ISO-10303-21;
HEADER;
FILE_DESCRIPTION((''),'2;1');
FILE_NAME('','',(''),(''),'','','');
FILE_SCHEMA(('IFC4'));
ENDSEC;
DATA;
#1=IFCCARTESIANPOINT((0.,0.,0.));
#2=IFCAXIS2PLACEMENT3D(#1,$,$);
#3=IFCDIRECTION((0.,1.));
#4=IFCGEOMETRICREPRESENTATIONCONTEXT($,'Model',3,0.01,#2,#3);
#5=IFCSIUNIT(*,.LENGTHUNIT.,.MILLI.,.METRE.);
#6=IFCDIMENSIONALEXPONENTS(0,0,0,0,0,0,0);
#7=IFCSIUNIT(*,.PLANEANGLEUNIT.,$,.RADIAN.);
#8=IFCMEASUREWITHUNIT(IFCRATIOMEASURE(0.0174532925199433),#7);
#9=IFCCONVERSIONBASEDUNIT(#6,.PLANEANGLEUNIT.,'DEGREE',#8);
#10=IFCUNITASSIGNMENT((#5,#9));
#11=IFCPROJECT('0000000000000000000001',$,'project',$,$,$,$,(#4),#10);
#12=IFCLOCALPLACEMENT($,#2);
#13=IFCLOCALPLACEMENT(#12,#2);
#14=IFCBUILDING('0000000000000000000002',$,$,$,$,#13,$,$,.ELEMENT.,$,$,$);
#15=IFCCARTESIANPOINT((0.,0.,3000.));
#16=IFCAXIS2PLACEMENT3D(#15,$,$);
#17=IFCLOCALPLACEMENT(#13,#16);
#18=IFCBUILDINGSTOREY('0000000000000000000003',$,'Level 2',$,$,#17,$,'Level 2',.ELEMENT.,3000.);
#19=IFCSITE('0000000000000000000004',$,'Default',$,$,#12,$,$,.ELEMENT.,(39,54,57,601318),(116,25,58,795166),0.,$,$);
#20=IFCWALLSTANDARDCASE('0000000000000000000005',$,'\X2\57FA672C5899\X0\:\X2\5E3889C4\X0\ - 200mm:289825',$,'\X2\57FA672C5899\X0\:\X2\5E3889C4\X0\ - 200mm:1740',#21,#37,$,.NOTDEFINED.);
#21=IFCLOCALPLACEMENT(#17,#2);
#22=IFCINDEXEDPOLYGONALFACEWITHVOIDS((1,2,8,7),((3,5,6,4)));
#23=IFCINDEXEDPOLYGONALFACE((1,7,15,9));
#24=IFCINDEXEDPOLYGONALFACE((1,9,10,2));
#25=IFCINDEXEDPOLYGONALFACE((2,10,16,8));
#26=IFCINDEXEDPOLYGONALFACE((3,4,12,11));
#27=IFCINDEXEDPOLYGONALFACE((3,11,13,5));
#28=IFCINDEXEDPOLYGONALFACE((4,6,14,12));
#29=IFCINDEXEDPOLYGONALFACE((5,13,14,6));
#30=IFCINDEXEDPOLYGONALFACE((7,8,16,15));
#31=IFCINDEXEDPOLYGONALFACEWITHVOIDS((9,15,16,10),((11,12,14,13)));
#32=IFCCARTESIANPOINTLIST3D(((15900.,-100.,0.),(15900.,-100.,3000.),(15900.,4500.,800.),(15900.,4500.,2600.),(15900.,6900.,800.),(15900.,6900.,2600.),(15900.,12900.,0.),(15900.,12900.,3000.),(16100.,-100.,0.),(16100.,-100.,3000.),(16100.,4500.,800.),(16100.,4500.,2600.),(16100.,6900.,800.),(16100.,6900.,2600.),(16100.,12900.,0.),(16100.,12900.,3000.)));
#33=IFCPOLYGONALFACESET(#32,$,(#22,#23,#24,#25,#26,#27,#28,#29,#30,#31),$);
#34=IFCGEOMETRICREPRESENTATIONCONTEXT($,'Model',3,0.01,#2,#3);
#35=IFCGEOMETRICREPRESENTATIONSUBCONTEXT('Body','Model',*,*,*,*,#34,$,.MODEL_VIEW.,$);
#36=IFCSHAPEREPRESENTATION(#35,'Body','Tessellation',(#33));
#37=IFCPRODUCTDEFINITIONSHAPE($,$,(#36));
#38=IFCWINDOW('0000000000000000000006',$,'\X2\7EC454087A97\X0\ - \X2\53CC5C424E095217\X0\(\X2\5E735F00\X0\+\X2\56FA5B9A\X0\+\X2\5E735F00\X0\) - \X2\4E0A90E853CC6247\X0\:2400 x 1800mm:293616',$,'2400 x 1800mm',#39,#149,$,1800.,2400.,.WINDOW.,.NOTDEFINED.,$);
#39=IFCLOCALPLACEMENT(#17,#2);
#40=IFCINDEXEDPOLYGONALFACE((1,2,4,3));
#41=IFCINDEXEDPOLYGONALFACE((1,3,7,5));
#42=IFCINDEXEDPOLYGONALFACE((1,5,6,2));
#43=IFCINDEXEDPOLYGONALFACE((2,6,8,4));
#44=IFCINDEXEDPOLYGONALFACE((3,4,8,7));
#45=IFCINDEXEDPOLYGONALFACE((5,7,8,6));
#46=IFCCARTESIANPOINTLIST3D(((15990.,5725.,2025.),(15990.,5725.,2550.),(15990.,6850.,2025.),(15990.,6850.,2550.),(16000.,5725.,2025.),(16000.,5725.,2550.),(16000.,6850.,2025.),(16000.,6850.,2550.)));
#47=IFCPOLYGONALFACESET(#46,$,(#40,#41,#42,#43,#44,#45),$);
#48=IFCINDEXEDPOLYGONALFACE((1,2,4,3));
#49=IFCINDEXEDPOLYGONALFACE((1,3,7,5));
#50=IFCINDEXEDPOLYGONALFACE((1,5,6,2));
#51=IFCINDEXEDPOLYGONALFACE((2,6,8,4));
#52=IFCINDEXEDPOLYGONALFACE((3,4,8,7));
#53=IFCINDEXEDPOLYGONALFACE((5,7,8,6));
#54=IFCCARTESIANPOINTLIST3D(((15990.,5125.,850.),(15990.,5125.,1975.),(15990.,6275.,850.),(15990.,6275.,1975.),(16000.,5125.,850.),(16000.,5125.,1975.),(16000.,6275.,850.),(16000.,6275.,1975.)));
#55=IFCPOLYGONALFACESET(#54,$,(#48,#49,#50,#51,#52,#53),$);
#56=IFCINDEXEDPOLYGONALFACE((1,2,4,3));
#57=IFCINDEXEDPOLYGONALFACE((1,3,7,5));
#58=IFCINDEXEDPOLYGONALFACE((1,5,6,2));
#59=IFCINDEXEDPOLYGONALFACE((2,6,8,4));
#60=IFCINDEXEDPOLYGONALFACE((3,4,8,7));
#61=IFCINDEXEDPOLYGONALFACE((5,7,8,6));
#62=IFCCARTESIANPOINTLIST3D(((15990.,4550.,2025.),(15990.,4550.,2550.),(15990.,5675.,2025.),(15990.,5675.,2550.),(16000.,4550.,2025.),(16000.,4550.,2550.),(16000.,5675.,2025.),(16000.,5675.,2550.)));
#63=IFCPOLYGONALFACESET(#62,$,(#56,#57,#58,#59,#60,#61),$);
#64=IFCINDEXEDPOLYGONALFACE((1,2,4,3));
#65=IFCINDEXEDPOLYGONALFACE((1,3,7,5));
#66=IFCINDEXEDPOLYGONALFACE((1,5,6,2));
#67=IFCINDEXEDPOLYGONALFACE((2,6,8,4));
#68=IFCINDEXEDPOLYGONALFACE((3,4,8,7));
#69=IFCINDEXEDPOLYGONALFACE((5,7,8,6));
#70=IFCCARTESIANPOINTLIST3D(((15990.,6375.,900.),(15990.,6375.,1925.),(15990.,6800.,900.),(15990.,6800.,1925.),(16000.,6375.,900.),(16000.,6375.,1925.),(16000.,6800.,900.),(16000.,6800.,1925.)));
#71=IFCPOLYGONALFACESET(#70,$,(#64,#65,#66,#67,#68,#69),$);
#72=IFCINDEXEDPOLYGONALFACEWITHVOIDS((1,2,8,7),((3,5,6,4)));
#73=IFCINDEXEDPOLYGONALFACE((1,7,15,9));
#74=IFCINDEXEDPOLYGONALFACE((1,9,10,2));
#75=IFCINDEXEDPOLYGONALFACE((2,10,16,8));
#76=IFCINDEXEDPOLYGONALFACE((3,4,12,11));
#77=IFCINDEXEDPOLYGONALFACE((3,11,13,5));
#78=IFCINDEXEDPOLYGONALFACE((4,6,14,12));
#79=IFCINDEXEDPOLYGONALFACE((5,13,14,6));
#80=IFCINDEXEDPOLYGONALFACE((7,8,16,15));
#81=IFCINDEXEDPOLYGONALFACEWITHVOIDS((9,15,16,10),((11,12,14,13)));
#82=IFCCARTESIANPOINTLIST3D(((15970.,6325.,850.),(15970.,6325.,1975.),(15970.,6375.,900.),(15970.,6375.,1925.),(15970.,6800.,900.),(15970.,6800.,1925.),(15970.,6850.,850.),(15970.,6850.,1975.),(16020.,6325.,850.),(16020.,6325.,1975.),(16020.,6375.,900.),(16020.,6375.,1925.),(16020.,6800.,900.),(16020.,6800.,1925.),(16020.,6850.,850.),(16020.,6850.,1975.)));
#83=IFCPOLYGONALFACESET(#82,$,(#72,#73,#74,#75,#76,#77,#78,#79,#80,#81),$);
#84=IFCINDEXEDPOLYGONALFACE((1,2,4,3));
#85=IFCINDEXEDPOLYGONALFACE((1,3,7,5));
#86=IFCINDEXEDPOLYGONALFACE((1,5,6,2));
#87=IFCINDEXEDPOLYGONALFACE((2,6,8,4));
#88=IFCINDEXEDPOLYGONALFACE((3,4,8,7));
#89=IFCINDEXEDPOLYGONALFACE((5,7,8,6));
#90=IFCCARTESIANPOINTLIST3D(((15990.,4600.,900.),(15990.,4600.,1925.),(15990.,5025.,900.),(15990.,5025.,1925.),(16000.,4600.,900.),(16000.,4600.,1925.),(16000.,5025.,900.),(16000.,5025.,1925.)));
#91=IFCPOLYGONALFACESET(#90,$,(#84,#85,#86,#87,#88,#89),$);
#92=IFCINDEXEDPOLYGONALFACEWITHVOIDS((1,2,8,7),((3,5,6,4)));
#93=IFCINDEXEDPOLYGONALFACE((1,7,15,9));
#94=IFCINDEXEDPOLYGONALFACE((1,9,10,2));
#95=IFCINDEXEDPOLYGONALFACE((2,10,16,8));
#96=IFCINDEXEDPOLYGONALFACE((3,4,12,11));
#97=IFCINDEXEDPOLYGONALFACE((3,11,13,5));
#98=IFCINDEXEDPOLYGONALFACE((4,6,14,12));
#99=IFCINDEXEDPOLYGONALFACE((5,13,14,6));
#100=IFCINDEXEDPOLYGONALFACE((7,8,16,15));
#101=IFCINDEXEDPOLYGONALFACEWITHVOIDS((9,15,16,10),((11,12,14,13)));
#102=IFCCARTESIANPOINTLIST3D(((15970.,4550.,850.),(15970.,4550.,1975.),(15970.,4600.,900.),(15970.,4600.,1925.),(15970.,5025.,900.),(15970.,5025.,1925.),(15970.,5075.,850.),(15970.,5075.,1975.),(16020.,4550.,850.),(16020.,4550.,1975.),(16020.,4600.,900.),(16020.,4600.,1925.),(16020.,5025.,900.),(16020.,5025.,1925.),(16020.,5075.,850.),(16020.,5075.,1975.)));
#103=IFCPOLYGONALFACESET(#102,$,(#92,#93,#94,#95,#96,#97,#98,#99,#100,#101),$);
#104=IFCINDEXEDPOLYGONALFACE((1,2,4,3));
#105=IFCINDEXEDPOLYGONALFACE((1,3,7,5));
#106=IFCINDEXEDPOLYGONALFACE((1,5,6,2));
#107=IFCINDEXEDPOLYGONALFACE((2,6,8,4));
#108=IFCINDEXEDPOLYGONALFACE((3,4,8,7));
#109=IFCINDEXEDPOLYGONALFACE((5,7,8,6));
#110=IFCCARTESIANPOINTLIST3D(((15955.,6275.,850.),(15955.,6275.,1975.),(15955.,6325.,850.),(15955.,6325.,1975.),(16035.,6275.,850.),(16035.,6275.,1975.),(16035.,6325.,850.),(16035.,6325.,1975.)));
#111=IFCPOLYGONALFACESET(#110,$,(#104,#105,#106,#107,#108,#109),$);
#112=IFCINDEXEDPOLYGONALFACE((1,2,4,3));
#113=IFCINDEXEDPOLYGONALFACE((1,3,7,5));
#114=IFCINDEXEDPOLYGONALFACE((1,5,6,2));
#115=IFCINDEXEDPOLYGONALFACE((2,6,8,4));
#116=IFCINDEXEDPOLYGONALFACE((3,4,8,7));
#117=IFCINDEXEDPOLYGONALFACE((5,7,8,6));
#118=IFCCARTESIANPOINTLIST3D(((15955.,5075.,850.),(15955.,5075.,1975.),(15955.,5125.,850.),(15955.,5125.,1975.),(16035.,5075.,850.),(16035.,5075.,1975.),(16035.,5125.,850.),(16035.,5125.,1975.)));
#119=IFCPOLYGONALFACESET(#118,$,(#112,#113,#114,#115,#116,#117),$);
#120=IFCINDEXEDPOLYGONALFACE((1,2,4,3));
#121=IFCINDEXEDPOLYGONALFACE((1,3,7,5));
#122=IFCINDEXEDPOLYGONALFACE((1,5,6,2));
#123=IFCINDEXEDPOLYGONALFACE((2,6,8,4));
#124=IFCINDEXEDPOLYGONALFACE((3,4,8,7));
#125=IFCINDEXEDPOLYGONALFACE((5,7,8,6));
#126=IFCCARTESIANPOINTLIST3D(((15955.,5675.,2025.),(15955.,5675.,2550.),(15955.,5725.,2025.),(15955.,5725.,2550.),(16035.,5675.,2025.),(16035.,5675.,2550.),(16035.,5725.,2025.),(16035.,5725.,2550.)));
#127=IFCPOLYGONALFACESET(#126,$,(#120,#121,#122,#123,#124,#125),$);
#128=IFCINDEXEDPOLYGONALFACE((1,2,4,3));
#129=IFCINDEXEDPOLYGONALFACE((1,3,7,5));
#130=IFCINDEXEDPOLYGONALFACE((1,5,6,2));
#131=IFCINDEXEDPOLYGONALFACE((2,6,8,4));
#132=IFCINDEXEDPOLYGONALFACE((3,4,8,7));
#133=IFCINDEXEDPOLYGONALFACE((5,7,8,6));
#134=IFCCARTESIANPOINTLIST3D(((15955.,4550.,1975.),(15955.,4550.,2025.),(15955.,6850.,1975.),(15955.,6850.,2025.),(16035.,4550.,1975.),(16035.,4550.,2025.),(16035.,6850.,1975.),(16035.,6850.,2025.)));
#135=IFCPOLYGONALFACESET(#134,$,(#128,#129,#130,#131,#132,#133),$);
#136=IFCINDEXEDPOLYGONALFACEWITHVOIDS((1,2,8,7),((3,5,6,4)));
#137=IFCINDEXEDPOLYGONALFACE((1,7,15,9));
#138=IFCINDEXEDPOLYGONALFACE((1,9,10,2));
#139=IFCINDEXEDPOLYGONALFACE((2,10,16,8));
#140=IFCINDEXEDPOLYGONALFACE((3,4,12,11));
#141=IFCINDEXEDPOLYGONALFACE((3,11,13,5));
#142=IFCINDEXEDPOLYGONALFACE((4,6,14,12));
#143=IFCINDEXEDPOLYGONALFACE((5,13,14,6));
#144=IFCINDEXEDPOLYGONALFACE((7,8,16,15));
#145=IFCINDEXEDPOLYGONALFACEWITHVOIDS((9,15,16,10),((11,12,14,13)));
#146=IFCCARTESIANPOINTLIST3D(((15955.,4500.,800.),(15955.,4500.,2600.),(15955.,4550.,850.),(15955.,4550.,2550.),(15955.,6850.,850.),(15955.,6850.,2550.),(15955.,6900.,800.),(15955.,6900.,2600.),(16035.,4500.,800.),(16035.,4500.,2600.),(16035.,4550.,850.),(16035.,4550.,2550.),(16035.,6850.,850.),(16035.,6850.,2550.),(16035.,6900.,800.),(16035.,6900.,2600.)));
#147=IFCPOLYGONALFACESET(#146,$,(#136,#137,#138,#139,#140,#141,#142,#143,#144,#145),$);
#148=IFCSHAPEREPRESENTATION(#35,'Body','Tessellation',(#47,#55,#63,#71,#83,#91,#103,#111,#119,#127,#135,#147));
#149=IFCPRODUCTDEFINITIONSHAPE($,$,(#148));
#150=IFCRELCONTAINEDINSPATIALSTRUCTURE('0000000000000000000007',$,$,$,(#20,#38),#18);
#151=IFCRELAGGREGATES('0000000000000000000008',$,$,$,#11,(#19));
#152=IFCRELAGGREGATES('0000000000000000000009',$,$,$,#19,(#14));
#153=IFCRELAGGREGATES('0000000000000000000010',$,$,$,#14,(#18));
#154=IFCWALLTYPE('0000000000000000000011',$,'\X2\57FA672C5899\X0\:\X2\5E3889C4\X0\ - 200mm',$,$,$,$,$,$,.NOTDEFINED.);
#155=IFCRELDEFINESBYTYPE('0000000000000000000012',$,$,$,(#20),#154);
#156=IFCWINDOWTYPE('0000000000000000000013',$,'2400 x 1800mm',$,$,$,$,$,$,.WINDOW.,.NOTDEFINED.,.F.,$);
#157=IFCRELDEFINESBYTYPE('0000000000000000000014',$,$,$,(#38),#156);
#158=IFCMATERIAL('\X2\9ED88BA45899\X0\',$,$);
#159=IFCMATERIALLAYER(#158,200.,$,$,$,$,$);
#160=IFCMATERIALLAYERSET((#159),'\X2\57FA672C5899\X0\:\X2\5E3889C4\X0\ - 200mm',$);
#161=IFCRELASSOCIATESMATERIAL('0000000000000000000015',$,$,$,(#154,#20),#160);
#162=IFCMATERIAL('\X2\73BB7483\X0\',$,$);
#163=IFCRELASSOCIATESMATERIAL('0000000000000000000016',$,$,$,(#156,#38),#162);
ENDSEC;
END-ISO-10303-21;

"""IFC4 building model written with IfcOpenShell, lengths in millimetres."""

from ifc_helpers import new_model, entity, si_unit, converted_unit, direction, frame, frame_2d, origin, origin_2d_with_axis, place, context, subcontext, project, spatial, polyline, rectangle, outline, extrude, source, transform, mapped, material, layer, layer_set, layer_usage, type_object, type_shapes, element, fill, save


model = new_model("IFC4")

# Units and contexts
model_context_1 = context("Model", 3, precision=0.01, world=origin(), true_north=direction((0.0, 1.0)))
model_context_2 = context("Model", 3, precision=0.01, world=origin(), true_north=direction((0.0, 1.0)))
body_context = subcontext(model_context_2, "Body", "Model", "MODEL_VIEW")
ifc_project = project(units=[si_unit("LENGTHUNIT", "METRE", prefix="MILLI"), converted_unit("PLANEANGLEUNIT", "DEGREE", entity("IfcRatioMeasure", 0.0174532925199433), si_unit("PLANEANGLEUNIT", "RADIAN"), dimensions=[0, 0, 0, 0, 0, 0, 0])], contexts=[model_context_1])

# Site, building, storey
site_placement = place(None, origin())
site = spatial("IfcSite", under=ifc_project, at=site_placement, Name="Default", CompositionType="ELEMENT", RefLatitude=(39, 54, 57, 601318), RefLongitude=(116, 25, 58, 795166), RefElevation=0.0)
building_placement = place(site_placement, origin())
building = spatial("IfcBuilding", under=site, at=building_placement, CompositionType="ELEMENT")
storey_placement = place(building_placement, frame((0.0, 0.0, 3000.0)))
storey = spatial("IfcBuildingStorey", under=building, at=storey_placement, Name="Level 2", LongName="Level 2", CompositionType="ELEMENT", Elevation=3000.0)

# Shared definitions
ifc_material_1 = material(Name="默认墙")
ifc_layer = layer(ifc_material_1, 200.0)
ifc_layer_set = layer_set([ifc_layer], Name="基本墙:常规 - 200mm")
wall_type = type_object("IfcWallType", Name="基本墙:常规 - 200mm", PredefinedType="NOTDEFINED", material=ifc_layer_set)

# Wall, opening, window
ifc_layer_usage_1 = layer_usage(ifc_layer_set, "AXIS2", "NEGATIVE", 100.0)
wall_1_placement = place(storey_placement, frame((16000.0, 12900.0, 0.0), z_axis=(0.0, 0.0, 1.0), x_axis=(0.0, -1.0, 0.0)))
wall_1 = element("IfcWallStandardCase", 1, at=wall_1_placement, inside=storey, type_object=wall_type, material=ifc_layer_usage_1, Name="基本墙:常规 - 200mm:289825", ObjectType="基本墙:常规 - 200mm:1740", PredefinedType="NOTDEFINED", context=body_context, shape_type="SweptSolid", body=[
    extrude(rectangle(XDim=13000.0, YDim=200.0, at=frame_2d((6500.0, 0.0), x_axis=(-1.0, 0.0))), origin(), (0.0, 0.0, 1.0), 3000.0),
])
opening_1_placement = place(wall_1_placement, frame((6000.0, -100.0, 800.0)))
opening_1 = element("IfcOpeningElement", 2, at=opening_1_placement, cuts=wall_1, ObjectType="Opening", PredefinedType="OPENING", context=body_context, shape_type="SweptSolid", body=[
    extrude(rectangle(XDim=1800.0, YDim=2400.0, at=frame_2d((900.0, 1200.0), x_axis=(1.0, 0.0))), frame((0.0, 0.0, 0.0), z_axis=(0.0, 1.0, 0.0), x_axis=(0.0, 0.0, 1.0)), (0.0, 0.0, 1.0), 200.0),
])
ifc_material_2 = material(Name="玻璃")
window_type_1 = type_object("IfcWindowType", Name="2400 x 1800mm", ParameterTakesPrecedence=False, PartitioningType="NOTDEFINED", PredefinedType="WINDOW", material=ifc_material_2)
shared_shape_1 = source(origin(), body_context, "Body", "SweptSolid", [
    extrude(rectangle(XDim=10.0, YDim=1125.0, at=origin_2d_with_axis()), frame((612.5, 95.0, 1225.0), z_axis=(0.0, 0.0, 1.0), x_axis=(0.0, 1.0, 0.0)), (0.0, 0.0, 1.0), 525.0),
    extrude(rectangle(XDim=10.0, YDim=1150.0, at=origin_2d_with_axis()), frame((1200.0, 95.0, 50.0), z_axis=(0.0, 0.0, 1.0), x_axis=(0.0, 1.0, 0.0)), (0.0, 0.0, 1.0), 1125.0),
    extrude(rectangle(XDim=10.0, YDim=1125.0, at=origin_2d_with_axis()), frame((1787.5, 95.0, 1225.0), z_axis=(0.0, 0.0, 1.0), x_axis=(0.0, 1.0, 0.0)), (0.0, 0.0, 1.0), 525.0),
    extrude(rectangle(XDim=10.0, YDim=425.0, at=origin_2d_with_axis()), frame((312.5, 95.0, 100.0), z_axis=(0.0, 0.0, 1.0), x_axis=(0.0, 1.0, 0.0)), (0.0, 0.0, 1.0), 1025.0),
    extrude(outline(polyline([(-562.5, -262.5), (562.5, -262.5), (562.5, 262.5), (-562.5, 262.5), (-562.5, -262.5)]), holes=[polyline([(512.5, -212.5), (-512.5, -212.5), (-512.5, 212.5), (512.5, 212.5), (512.5, -212.5)])]), frame((312.5, 70.0, 612.5), z_axis=(0.0, 1.0, 0.0), x_axis=(0.0, 0.0, -1.0)), (0.0, 0.0, 1.0), 50.0),
    extrude(rectangle(XDim=10.0, YDim=425.0, at=origin_2d_with_axis()), frame((2087.5, 95.0, 100.0), z_axis=(0.0, 0.0, 1.0), x_axis=(0.0, 1.0, 0.0)), (0.0, 0.0, 1.0), 1025.0),
    extrude(outline(polyline([(-562.5, -262.5), (562.5, -262.5), (562.5, 262.5), (-562.5, 262.5), (-562.5, -262.5)]), holes=[polyline([(512.5, -212.5), (-512.5, -212.5), (-512.5, 212.5), (512.5, 212.5), (512.5, -212.5)])]), frame((2087.5, 70.0, 612.5), z_axis=(0.0, 1.0, 0.0), x_axis=(0.0, 0.0, -1.0)), (0.0, 0.0, 1.0), 50.0),
    extrude(rectangle(XDim=80.0, YDim=50.0, at=origin_2d_with_axis()), frame((600.0, 95.0, 50.0), z_axis=(0.0, 0.0, 1.0), x_axis=(0.0, -1.0, 0.0)), (0.0, 0.0, 1.0), 1125.0),
    extrude(rectangle(XDim=80.0, YDim=50.0, at=origin_2d_with_axis()), frame((1800.0, 95.0, 50.0), z_axis=(0.0, 0.0, 1.0), x_axis=(0.0, -1.0, 0.0)), (0.0, 0.0, 1.0), 1125.0),
    extrude(rectangle(XDim=80.0, YDim=50.0, at=origin_2d_with_axis()), frame((1200.0, 95.0, 1225.0), z_axis=(0.0, 0.0, 1.0), x_axis=(0.0, -1.0, 0.0)), (0.0, 0.0, 1.0), 525.0),
    extrude(rectangle(XDim=80.0, YDim=2300.0, at=origin_2d_with_axis()), frame((1200.0, 95.0, 1175.0), z_axis=(0.0, 0.0, 1.0), x_axis=(0.0, -1.0, 0.0)), (0.0, 0.0, 1.0), 50.0),
    extrude(outline(polyline([(-1200.0, -900.0), (1200.0, -900.0), (1200.0, 900.0), (-1200.0, 900.0), (-1200.0, -900.0)]), holes=[polyline([(1150.0, -850.0), (-1150.0, -850.0), (-1150.0, 850.0), (1150.0, 850.0), (1150.0, -850.0)])]), frame((1200.0, 55.0, 900.0), z_axis=(0.0, 1.0, 0.0), x_axis=(1.0, 0.0, 0.0)), (0.0, 0.0, 1.0), 80.0),
])
type_shapes(window_type_1, [shared_shape_1])
window_1_placement = place(opening_1_placement, origin())
window_1 = element("IfcWindow", 3, at=window_1_placement, inside=storey, type_object=window_type_1, material=ifc_material_2, Name="组合窗 - 双层三列(平开+固定+平开) - 上部双扇:2400 x 1800mm:293616", ObjectType="2400 x 1800mm", OverallHeight=1800.0, OverallWidth=2400.0, PartitioningType="NOTDEFINED", PredefinedType="WINDOW", context=body_context, shape_type="MappedRepresentation", body=[
    mapped(shared_shape_1, transform((0.0, 0.0, 0.0), scale=1.0)),
])
fill(opening_1, window_1)

save(model, "model.ifc")
